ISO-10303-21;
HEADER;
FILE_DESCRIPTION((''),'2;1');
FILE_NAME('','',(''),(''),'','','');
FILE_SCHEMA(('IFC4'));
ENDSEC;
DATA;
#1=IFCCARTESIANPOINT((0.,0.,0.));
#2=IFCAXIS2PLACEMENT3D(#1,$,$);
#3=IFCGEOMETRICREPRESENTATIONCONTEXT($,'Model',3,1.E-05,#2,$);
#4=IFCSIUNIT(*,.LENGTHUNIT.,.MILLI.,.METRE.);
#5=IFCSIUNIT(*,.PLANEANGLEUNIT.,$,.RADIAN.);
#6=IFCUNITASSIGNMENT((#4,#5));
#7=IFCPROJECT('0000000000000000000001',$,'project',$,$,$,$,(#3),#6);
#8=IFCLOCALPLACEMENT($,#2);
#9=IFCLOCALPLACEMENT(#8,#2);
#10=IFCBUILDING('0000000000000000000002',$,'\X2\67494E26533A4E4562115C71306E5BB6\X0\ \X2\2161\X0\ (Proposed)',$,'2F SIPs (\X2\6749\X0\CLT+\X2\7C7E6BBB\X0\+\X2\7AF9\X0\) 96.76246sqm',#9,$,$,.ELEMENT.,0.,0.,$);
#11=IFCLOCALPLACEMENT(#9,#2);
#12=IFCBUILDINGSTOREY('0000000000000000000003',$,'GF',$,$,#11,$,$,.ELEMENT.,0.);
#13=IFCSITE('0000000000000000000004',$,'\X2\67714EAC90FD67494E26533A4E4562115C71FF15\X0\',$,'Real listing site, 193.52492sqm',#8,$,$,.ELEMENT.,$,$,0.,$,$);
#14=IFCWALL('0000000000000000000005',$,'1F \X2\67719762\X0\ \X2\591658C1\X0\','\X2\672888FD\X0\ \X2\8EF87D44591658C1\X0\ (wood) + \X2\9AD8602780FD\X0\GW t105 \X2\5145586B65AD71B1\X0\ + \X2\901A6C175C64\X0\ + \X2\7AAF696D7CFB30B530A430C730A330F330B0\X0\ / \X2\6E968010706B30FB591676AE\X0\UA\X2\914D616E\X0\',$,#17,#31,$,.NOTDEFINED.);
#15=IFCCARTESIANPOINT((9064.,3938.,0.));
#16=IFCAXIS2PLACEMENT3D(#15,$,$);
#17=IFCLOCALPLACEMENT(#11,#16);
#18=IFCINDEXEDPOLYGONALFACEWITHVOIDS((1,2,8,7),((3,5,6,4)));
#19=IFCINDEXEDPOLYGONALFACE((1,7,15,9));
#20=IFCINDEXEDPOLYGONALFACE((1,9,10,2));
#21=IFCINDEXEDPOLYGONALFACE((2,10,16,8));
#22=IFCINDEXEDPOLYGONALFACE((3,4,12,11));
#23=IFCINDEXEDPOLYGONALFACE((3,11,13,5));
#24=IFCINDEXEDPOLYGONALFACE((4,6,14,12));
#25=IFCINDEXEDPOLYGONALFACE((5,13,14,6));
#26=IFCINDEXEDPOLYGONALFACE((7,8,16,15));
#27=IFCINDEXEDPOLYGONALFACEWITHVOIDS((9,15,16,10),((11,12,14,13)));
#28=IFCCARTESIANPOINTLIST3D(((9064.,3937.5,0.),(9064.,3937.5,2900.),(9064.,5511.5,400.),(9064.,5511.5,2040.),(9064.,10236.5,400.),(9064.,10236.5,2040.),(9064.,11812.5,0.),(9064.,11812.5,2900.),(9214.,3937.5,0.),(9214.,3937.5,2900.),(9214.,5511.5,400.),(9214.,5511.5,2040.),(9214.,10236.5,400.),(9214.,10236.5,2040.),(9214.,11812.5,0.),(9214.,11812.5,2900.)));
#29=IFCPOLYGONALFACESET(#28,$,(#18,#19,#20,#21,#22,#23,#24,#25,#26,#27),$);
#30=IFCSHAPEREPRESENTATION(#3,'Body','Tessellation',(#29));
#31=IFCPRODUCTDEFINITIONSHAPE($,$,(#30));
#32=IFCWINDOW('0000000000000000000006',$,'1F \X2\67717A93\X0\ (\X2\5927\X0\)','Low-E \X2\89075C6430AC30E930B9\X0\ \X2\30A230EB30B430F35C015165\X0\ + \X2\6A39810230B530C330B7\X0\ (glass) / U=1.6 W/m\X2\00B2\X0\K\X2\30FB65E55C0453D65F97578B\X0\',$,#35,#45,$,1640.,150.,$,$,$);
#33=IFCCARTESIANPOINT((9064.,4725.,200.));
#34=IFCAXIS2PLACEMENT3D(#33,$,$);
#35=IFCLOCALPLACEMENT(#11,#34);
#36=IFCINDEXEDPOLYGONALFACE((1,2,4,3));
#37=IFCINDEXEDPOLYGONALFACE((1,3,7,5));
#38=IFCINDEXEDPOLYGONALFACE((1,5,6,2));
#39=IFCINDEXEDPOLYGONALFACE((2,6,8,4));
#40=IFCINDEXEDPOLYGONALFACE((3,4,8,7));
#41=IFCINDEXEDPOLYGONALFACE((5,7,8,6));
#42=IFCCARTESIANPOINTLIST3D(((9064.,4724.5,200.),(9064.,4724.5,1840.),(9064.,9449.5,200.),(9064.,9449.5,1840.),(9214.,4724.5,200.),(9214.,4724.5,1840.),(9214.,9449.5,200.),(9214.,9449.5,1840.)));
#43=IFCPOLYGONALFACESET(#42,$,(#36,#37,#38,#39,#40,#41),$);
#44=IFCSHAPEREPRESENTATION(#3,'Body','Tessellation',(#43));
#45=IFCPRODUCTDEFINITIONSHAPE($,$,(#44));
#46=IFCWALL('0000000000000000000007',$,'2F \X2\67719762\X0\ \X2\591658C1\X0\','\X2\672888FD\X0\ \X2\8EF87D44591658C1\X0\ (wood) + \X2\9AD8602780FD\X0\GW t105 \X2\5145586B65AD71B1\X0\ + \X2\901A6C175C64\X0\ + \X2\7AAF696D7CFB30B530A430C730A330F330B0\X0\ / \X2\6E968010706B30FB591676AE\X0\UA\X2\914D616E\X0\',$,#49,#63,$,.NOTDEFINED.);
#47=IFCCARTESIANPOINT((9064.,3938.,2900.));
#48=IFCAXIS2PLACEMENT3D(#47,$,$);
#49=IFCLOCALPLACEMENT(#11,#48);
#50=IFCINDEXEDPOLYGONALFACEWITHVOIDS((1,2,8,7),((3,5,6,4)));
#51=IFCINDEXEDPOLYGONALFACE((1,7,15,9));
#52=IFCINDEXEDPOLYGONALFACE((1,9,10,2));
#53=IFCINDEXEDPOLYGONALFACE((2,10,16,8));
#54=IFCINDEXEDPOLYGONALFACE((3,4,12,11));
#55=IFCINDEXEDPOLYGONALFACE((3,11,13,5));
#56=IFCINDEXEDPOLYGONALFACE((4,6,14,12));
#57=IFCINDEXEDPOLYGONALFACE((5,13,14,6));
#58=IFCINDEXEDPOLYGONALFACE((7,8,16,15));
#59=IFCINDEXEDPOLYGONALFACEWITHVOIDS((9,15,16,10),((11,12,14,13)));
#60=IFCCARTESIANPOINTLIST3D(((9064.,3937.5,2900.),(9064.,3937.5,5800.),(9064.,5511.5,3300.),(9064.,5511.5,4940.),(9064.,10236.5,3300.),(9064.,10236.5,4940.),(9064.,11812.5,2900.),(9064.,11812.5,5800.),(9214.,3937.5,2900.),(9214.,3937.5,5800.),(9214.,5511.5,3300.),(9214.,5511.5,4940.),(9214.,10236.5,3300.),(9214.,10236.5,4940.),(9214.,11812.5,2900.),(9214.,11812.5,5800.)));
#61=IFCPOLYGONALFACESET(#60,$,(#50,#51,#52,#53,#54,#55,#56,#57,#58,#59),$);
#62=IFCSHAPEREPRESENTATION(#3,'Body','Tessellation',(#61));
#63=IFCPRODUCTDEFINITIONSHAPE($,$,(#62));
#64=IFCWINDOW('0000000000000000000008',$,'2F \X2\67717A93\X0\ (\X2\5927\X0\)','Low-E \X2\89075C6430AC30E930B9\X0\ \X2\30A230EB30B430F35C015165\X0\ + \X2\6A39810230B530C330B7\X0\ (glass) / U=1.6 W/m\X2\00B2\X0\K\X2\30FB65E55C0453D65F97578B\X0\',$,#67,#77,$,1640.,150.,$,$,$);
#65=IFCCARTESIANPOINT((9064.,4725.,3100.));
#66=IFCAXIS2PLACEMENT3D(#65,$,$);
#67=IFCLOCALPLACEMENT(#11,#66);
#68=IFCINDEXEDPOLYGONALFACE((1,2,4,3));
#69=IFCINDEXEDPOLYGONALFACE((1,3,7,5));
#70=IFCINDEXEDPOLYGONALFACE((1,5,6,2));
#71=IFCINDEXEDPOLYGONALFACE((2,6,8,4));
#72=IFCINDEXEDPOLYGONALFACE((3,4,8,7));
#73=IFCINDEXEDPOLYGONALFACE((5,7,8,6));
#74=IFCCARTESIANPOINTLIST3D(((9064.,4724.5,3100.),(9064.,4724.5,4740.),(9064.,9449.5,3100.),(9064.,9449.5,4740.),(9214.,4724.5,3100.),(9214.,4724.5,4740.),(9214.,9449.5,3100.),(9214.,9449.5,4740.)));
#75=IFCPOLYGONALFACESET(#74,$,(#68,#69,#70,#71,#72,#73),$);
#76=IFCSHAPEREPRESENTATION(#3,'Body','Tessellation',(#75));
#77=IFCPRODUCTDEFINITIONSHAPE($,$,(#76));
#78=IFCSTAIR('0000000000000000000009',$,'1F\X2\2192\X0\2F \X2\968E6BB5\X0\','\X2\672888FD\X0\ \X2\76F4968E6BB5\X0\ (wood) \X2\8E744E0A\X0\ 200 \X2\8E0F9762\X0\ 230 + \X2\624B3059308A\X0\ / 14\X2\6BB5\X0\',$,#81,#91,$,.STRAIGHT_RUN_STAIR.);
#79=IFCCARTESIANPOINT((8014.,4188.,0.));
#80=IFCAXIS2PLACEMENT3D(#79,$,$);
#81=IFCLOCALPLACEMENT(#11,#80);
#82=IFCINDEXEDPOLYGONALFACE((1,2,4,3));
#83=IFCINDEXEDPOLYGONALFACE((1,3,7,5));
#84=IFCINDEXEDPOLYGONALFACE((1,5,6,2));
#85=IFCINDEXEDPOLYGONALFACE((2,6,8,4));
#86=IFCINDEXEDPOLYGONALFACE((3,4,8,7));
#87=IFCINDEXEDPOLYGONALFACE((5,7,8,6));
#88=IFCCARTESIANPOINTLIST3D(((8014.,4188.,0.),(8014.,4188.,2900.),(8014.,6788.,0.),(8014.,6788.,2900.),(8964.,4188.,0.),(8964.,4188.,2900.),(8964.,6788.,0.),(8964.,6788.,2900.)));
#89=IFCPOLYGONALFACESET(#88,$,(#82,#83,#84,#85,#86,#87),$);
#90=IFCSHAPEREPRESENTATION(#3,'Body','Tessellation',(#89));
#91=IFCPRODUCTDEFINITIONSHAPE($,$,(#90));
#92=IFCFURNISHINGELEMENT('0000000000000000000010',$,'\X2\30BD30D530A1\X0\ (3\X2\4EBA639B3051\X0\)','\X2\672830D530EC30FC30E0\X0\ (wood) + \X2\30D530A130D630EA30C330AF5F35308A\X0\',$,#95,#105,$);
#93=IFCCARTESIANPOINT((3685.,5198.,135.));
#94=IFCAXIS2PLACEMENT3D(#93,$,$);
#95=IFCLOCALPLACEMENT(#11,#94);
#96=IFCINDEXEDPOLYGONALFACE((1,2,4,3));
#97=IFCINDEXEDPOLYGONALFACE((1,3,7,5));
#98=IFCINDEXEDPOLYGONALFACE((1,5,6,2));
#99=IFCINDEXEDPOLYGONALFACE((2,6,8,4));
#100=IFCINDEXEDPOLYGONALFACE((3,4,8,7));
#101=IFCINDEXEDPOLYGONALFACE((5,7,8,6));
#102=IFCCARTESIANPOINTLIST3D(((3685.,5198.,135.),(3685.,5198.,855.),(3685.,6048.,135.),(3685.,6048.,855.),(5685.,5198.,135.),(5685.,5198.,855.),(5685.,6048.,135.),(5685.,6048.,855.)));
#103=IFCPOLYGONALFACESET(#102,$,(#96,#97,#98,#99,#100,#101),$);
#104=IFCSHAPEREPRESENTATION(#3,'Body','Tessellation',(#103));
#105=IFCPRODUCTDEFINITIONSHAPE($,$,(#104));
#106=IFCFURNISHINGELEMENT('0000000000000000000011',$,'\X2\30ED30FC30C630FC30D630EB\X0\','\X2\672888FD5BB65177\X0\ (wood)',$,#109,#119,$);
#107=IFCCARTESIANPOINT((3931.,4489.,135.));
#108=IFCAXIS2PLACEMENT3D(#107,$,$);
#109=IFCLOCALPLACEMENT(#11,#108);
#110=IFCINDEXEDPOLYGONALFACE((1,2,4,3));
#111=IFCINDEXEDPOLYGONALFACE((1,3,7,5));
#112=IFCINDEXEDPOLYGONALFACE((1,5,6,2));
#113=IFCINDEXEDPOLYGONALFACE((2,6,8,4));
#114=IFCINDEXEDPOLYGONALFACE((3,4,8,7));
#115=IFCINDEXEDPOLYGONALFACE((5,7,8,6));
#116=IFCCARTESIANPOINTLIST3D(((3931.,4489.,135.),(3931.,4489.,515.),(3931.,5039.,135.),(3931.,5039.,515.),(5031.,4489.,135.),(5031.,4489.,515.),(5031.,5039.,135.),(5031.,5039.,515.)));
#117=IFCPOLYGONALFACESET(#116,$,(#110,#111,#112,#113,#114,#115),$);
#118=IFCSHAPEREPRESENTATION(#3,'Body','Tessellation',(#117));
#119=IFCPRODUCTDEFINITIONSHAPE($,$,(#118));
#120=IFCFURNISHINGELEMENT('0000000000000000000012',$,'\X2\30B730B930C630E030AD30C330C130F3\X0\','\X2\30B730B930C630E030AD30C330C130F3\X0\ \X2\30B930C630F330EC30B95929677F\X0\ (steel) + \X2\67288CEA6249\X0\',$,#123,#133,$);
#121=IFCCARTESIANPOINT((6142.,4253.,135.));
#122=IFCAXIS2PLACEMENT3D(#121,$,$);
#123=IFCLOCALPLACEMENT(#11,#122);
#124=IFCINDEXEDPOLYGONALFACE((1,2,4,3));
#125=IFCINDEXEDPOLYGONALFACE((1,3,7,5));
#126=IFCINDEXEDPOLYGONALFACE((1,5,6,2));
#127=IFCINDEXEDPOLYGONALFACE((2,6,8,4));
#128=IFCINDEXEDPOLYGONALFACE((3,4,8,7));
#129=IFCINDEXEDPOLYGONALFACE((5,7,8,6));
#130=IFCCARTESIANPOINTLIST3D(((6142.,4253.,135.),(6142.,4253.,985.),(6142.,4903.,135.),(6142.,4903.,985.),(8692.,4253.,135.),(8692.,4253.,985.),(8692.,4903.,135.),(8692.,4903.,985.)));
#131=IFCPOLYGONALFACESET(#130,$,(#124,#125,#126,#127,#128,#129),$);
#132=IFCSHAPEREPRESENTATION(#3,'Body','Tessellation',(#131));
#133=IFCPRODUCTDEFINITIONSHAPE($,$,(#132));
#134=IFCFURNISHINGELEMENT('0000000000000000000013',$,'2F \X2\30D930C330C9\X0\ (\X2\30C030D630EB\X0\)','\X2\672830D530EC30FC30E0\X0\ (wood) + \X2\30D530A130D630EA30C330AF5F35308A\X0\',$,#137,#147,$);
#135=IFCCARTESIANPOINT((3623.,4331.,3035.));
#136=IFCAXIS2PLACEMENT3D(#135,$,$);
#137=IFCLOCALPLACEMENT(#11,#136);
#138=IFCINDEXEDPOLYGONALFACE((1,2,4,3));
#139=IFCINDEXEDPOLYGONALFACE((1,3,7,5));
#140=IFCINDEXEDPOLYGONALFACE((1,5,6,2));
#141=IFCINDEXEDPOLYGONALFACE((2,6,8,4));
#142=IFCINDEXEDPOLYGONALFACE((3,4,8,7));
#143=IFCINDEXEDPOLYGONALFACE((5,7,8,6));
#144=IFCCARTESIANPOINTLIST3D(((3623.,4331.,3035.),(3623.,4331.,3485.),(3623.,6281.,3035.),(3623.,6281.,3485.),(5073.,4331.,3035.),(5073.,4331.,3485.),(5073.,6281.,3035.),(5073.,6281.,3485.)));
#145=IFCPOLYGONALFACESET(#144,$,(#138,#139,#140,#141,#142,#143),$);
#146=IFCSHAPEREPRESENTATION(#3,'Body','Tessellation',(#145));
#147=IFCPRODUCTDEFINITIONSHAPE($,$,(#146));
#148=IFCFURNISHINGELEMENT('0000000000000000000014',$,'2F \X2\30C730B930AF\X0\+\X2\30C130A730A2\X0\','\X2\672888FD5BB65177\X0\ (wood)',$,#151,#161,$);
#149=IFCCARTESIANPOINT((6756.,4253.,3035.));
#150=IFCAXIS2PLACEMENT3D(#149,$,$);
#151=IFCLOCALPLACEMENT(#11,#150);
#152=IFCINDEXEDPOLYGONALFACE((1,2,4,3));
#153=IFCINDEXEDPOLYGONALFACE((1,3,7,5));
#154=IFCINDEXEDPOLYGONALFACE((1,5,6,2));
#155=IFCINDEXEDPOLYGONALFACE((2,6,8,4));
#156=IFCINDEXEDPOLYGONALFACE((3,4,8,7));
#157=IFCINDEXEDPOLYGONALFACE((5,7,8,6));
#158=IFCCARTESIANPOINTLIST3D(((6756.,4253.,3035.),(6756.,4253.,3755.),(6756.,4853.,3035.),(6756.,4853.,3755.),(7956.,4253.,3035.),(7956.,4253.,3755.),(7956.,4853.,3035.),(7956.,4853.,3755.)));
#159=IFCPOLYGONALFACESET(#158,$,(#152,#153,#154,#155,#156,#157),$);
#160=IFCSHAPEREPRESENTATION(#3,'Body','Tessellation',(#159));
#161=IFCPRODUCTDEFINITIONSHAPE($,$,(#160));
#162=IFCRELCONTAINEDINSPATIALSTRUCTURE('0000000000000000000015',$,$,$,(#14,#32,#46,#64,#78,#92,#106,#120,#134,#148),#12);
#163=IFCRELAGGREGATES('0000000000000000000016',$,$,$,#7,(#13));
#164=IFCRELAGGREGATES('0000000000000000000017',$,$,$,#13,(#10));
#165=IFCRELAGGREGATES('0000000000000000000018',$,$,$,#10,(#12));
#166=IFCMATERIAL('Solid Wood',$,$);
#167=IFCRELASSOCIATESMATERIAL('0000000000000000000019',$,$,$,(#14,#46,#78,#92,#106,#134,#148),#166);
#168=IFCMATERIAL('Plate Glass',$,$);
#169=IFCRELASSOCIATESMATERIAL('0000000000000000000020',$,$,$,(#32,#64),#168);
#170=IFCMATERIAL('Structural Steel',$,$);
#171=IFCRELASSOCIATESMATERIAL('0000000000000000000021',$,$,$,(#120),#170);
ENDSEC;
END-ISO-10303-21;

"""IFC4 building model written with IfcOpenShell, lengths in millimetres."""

from ifc_helpers import new_model, si_unit, frame, frame_2d, origin, place, context, project, spatial, rectangle, extrude, material, element, fill, save


model = new_model("IFC4")

# Units and contexts
model_context = context("Model", 3, precision=1e-05, world=origin())
ifc_project = project(units=[si_unit("LENGTHUNIT", "METRE", prefix="MILLI"), si_unit("PLANEANGLEUNIT", "RADIAN")], contexts=[model_context])

# Site, building, storey
site_placement = place(None, origin())
site = spatial("IfcSite", under=ifc_project, at=site_placement, Name="東京都杉並区久我山５", ObjectType="Real listing site, 193.52492sqm", CompositionType="ELEMENT", RefElevation=0.0)
building_placement = place(site_placement, origin())
building = spatial("IfcBuilding", under=site, at=building_placement, Name="杉並区久我山の家 Ⅱ (Proposed)", ObjectType="2F SIPs (杉CLT+籾殻+竹) 96.76246sqm", CompositionType="ELEMENT", ElevationOfRefHeight=0.0, ElevationOfTerrain=0.0)
storey_placement = place(building_placement, origin())
storey = spatial("IfcBuildingStorey", under=building, at=storey_placement, Name="GF", CompositionType="ELEMENT", Elevation=0.0)

# Wall, opening, window
ifc_material_1 = material(Name="Solid Wood")
wall_1_placement = place(storey_placement, frame((9064.0, 3938.0, 0.0)))
wall_1 = element("IfcWall", 1, at=wall_1_placement, inside=storey, material=ifc_material_1, Name="1F 東面 外壁", Description="木製 軸組外壁 (wood) + 高性能GW t105 充填断熱 + 通気層 + 窯業系サイディング / 準耐火・外皮UA配慮", PredefinedType="NOTDEFINED", context=model_context, shape_type="SweptSolid", body=[
    extrude(rectangle(XDim=150.0, YDim=7875.0, at=frame_2d((75.0, 3937.0))), frame((9064.0, 3938.0, 0.0)), (0.0, 0.0, 1.0), 2900.0),
])
opening_1_placement = place(storey_placement, frame((9064.0, 4725.0, 200.0)))
opening_1 = element("IfcOpeningElement", 2, at=opening_1_placement, cuts=wall_1, PredefinedType="NOTDEFINED", context=model_context, shape_type="SweptSolid", body=[
    extrude(rectangle(XDim=150.0, YDim=4725.0, at=frame_2d((75.0, 2362.0))), frame((9064.0, 4725.0, 200.0)), (0.0, 0.0, 1.0), 1640.0),
])
ifc_material_2 = material(Name="Plate Glass")
window_1_placement = place(storey_placement, frame((9064.0, 4725.0, 200.0)))
window_1 = element("IfcWindow", 3, at=window_1_placement, inside=storey, material=ifc_material_2, Name="1F 東窓 (大)", Description="Low-E 複層ガラス アルゴン封入 + 樹脂サッシ (glass) / U=1.6 W/m²K・日射取得型", OverallHeight=1640.0, OverallWidth=150.0, context=model_context, shape_type="SweptSolid", body=[
    extrude(rectangle(XDim=150.0, YDim=4725.0, at=frame_2d((75.0, 2362.0))), frame((9064.0, 4725.0, 200.0)), (0.0, 0.0, 1.0), 1640.0),
])
fill(opening_1, window_1)

# Wall, opening, window
wall_2_placement = place(storey_placement, frame((9064.0, 3938.0, 2900.0)))
wall_2 = element("IfcWall", 4, at=wall_2_placement, inside=storey, material=ifc_material_1, Name="2F 東面 外壁", Description="木製 軸組外壁 (wood) + 高性能GW t105 充填断熱 + 通気層 + 窯業系サイディング / 準耐火・外皮UA配慮", PredefinedType="NOTDEFINED", context=model_context, shape_type="SweptSolid", body=[
    extrude(rectangle(XDim=150.0, YDim=7875.0, at=frame_2d((75.0, 3937.0))), frame((9064.0, 3938.0, 2900.0)), (0.0, 0.0, 1.0), 2900.0),
])
opening_2_placement = place(storey_placement, frame((9064.0, 4725.0, 3100.0)))
opening_2 = element("IfcOpeningElement", 5, at=opening_2_placement, cuts=wall_2, PredefinedType="NOTDEFINED", context=model_context, shape_type="SweptSolid", body=[
    extrude(rectangle(XDim=150.0, YDim=4725.0, at=frame_2d((75.0, 2362.0))), frame((9064.0, 4725.0, 3100.0)), (0.0, 0.0, 1.0), 1640.0),
])
window_2_placement = place(storey_placement, frame((9064.0, 4725.0, 3100.0)))
window_2 = element("IfcWindow", 6, at=window_2_placement, inside=storey, material=ifc_material_2, Name="2F 東窓 (大)", Description="Low-E 複層ガラス アルゴン封入 + 樹脂サッシ (glass) / U=1.6 W/m²K・日射取得型", OverallHeight=1640.0, OverallWidth=150.0, context=model_context, shape_type="SweptSolid", body=[
    extrude(rectangle(XDim=150.0, YDim=4725.0, at=frame_2d((75.0, 2362.0))), frame((9064.0, 4725.0, 3100.0)), (0.0, 0.0, 1.0), 1640.0),
])
fill(opening_2, window_2)

# Stair
stair_placement = place(storey_placement, frame((8014.0, 4188.0, 0.0)))
element("IfcStair", 7, at=stair_placement, inside=storey, material=ifc_material_1, Name="1F→2F 階段", Description="木製 直階段 (wood) 蹴上 200 踏面 230 + 手すり / 14段", PredefinedType="STRAIGHT_RUN_STAIR", context=model_context, shape_type="SweptSolid", body=[
    extrude(rectangle(XDim=950.0, YDim=2600.0, at=frame_2d((475.0, 1300.0))), frame((8014.0, 4188.0, 0.0)), (0.0, 0.0, 1.0), 2900.0),
])

# Furnishing elements
furnishing_1_placement = place(storey_placement, frame((3685.0, 5198.0, 135.0)))
element("IfcFurnishingElement", 8, at=furnishing_1_placement, inside=storey, material=ifc_material_1, Name="ソファ (3人掛け)", Description="木フレーム (wood) + ファブリック張り", context=model_context, shape_type="SweptSolid", body=[
    extrude(rectangle(XDim=2000.0, YDim=850.0, at=frame_2d((1000.0, 425.0))), frame((3685.0, 5198.0, 135.0)), (0.0, 0.0, 1.0), 720.0),
])
furnishing_2_placement = place(storey_placement, frame((3931.0, 4489.0, 135.0)))
element("IfcFurnishingElement", 9, at=furnishing_2_placement, inside=storey, material=ifc_material_1, Name="ローテーブル", Description="木製家具 (wood)", context=model_context, shape_type="SweptSolid", body=[
    extrude(rectangle(XDim=1100.0, YDim=550.0, at=frame_2d((550.0, 275.0))), frame((3931.0, 4489.0, 135.0)), (0.0, 0.0, 1.0), 380.0),
])
ifc_material_3 = material(Name="Structural Steel")
furnishing_3_placement = place(storey_placement, frame((6142.0, 4253.0, 135.0)))
element("IfcFurnishingElement", 10, at=furnishing_3_placement, inside=storey, material=ifc_material_3, Name="システムキッチン", Description="システムキッチン ステンレス天板 (steel) + 木質扉", context=model_context, shape_type="SweptSolid", body=[
    extrude(rectangle(XDim=2550.0, YDim=650.0, at=frame_2d((1275.0, 325.0))), frame((6142.0, 4253.0, 135.0)), (0.0, 0.0, 1.0), 850.0),
])
furnishing_4_placement = place(storey_placement, frame((3623.0, 4331.0, 3035.0)))
element("IfcFurnishingElement", 11, at=furnishing_4_placement, inside=storey, material=ifc_material_1, Name="2F ベッド (ダブル)", Description="木フレーム (wood) + ファブリック張り", context=model_context, shape_type="SweptSolid", body=[
    extrude(rectangle(XDim=1450.0, YDim=1950.0, at=frame_2d((725.0, 975.0))), frame((3623.0, 4331.0, 3035.0)), (0.0, 0.0, 1.0), 450.0),
])
furnishing_5_placement = place(storey_placement, frame((6756.0, 4253.0, 3035.0)))
element("IfcFurnishingElement", 12, at=furnishing_5_placement, inside=storey, material=ifc_material_1, Name="2F デスク+チェア", Description="木製家具 (wood)", context=model_context, shape_type="SweptSolid", body=[
    extrude(rectangle(XDim=1200.0, YDim=600.0, at=frame_2d((600.0, 300.0))), frame((6756.0, 4253.0, 3035.0)), (0.0, 0.0, 1.0), 720.0),
])

save(model, "model.ifc")
